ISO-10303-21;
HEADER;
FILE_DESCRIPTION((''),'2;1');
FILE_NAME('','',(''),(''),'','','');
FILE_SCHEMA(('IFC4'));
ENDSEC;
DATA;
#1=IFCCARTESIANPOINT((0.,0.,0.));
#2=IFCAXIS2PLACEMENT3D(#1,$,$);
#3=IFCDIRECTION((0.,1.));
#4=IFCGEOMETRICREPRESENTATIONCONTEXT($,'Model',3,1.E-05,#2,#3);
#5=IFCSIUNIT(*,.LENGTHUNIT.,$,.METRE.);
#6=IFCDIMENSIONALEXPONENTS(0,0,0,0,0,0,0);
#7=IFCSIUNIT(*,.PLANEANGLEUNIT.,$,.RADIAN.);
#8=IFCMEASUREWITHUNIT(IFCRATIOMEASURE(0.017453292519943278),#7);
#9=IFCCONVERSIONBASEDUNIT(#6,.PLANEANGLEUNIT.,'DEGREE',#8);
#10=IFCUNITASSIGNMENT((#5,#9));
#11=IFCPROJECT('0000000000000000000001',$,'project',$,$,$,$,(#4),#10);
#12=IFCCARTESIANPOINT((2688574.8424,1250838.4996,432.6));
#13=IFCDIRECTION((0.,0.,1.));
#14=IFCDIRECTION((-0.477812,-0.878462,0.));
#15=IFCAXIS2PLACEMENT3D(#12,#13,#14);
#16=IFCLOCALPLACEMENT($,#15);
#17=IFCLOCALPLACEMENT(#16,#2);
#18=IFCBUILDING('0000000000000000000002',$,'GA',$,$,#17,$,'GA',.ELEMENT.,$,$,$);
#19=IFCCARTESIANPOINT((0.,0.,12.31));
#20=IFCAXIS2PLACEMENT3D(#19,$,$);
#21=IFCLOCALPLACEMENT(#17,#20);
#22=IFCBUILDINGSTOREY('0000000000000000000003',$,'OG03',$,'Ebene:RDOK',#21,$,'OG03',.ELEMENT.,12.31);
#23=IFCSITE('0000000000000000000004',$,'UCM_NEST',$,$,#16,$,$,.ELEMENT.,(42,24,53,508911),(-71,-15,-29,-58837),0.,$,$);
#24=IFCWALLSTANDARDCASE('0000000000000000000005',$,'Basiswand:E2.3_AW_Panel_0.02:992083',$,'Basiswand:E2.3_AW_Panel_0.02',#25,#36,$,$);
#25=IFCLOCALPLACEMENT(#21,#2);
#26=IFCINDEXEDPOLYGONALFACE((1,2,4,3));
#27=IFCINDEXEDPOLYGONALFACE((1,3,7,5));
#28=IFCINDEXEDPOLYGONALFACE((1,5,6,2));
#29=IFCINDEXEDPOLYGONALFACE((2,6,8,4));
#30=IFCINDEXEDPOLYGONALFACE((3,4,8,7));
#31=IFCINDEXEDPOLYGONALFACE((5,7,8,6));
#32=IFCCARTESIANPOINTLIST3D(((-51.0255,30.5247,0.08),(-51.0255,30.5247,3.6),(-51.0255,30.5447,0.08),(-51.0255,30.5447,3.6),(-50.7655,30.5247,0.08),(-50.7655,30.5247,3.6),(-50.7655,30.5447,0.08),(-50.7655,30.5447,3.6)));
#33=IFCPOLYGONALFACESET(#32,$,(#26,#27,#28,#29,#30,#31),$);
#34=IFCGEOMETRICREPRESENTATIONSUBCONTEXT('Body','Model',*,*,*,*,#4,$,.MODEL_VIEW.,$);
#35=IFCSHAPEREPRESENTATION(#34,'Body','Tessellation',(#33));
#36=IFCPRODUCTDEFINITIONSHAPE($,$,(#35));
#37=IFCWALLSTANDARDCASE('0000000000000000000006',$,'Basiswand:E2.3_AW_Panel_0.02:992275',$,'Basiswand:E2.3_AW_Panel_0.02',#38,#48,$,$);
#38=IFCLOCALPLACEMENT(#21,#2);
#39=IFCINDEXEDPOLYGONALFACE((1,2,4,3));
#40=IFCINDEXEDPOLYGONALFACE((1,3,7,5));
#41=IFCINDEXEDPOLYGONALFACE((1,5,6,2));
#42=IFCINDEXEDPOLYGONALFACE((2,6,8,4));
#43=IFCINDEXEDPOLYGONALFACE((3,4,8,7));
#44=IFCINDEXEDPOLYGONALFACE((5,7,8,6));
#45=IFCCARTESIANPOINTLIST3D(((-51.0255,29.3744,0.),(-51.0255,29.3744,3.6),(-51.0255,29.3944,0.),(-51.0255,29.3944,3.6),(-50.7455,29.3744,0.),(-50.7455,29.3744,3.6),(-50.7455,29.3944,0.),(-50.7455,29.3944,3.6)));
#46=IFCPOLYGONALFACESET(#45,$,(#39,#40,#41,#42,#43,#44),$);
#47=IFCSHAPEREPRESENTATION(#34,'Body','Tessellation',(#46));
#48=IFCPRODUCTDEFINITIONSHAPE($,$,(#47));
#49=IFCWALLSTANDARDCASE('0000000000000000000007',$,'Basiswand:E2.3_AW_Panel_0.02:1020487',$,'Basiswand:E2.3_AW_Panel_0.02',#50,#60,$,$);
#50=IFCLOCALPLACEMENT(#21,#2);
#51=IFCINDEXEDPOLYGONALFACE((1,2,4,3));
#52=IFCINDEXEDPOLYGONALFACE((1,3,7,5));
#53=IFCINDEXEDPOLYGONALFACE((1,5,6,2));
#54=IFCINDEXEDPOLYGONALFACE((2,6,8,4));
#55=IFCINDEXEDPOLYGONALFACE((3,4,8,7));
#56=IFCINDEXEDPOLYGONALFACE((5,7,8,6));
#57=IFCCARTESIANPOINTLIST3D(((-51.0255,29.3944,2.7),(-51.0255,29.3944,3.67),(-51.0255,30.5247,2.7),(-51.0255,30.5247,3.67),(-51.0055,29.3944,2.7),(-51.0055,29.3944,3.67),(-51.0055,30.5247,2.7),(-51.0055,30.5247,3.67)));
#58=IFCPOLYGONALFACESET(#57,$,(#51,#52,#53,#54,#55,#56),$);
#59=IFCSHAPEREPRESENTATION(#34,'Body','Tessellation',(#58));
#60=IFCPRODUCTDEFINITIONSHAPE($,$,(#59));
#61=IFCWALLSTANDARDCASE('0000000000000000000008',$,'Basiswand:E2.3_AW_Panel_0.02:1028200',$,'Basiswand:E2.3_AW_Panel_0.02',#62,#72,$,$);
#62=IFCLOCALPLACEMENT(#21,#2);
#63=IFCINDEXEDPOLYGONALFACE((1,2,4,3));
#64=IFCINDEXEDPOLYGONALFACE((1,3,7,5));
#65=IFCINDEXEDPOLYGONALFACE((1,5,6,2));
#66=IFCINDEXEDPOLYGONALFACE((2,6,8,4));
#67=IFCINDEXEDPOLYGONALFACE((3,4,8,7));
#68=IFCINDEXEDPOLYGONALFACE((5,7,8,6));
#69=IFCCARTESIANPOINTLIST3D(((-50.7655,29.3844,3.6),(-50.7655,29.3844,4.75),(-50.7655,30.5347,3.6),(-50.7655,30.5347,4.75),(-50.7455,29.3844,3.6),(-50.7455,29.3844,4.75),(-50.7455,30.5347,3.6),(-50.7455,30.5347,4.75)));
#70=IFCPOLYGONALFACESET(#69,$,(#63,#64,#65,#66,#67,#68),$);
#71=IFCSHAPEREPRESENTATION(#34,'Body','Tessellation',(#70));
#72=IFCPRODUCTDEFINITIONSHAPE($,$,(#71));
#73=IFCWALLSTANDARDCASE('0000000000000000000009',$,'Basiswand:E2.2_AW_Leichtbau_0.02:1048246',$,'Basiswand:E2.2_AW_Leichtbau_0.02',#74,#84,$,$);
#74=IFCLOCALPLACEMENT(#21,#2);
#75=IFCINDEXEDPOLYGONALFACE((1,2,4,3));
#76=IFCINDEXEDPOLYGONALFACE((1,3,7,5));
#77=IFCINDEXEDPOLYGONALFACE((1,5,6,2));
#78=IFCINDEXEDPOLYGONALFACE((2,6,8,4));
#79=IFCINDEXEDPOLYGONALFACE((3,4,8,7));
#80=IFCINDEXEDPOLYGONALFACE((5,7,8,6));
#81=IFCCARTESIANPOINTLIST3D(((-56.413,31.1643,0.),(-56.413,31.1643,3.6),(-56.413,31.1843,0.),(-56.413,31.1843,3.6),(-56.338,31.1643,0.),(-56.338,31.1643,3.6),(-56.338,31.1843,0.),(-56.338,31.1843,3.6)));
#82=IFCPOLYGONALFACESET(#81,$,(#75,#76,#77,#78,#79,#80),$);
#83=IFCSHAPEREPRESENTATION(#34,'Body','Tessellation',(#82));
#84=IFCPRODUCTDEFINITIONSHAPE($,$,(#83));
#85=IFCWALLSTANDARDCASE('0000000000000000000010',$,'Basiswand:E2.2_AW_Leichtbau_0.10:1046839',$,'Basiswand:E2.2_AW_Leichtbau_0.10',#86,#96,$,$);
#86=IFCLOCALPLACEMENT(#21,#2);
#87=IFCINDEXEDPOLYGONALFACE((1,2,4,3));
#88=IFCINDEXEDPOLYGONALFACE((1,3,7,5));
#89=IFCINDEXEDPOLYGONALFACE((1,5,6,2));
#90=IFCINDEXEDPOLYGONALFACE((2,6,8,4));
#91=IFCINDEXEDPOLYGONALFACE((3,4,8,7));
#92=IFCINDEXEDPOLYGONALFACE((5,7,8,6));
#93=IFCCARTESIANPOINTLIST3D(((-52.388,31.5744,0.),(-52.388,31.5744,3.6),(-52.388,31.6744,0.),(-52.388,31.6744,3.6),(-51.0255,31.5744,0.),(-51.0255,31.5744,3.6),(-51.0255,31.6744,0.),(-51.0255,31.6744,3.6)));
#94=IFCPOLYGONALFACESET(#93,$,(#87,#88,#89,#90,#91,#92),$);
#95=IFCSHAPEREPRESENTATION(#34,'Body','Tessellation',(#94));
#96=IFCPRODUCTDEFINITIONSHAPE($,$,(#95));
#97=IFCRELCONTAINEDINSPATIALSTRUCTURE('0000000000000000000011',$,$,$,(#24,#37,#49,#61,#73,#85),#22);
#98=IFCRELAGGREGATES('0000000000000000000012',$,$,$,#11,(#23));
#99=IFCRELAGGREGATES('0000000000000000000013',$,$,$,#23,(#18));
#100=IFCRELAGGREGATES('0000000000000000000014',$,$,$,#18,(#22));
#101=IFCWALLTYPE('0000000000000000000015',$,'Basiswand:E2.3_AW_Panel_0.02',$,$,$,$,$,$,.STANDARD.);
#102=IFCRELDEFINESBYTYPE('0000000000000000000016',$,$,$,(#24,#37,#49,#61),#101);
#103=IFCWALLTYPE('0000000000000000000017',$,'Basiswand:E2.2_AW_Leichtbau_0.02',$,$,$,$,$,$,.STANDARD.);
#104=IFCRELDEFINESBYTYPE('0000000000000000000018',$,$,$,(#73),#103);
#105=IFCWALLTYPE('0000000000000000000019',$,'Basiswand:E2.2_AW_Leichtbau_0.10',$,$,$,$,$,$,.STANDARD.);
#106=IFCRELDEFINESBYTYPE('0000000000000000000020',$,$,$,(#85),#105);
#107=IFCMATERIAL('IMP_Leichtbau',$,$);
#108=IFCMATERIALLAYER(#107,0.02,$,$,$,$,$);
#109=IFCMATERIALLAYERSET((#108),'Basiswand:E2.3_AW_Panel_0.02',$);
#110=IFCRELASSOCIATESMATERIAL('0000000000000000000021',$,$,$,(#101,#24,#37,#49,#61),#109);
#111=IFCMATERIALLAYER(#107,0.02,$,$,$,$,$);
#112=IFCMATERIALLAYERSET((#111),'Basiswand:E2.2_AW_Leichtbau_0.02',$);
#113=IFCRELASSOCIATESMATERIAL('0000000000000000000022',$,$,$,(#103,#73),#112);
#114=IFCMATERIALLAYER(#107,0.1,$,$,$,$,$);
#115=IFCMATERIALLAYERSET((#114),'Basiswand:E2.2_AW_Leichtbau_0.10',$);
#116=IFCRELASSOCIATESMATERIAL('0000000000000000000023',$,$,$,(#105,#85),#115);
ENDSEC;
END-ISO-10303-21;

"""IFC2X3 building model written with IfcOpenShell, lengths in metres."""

from ifc_helpers import new_model, entity, si_unit, converted_unit, direction, frame, frame_2d, origin, place, context, subcontext, project, spatial, polyline, rectangle, extrude, clip, bounded_halfspace, material, layer, layer_set, layer_usage, type_object, element, save


model = new_model("IFC2X3")

# Units and contexts
model_context = context("Model", 3, precision=1e-05, world=origin(), true_north=direction((0.0, 1.0)))
body_context = subcontext(model_context, "Body", "Model", "MODEL_VIEW")
ifc_project = project(units=[si_unit("LENGTHUNIT", "METRE"), converted_unit("PLANEANGLEUNIT", "DEGREE", entity("IfcRatioMeasure", 0.017453292519943278), si_unit("PLANEANGLEUNIT", "RADIAN"), dimensions=[0, 0, 0, 0, 0, 0, 0])], contexts=[model_context])

# Site, building, storey
site_placement = place(None, frame((2688574.8424, 1250838.4996, 432.6), z_axis=(0.0, 0.0, 1.0), x_axis=(-0.477812, -0.878462, 0.0)))
site = spatial("IfcSite", under=ifc_project, at=site_placement, Name="UCM_NEST", CompositionType="ELEMENT", RefLatitude=(42, 24, 53, 508911), RefLongitude=(-71, -15, -29, -58837), RefElevation=0.0)
building_placement = place(site_placement, origin())
building = spatial("IfcBuilding", under=site, at=building_placement, Name="GA", LongName="GA", CompositionType="ELEMENT")
storey_placement = place(building_placement, frame((0.0, 0.0, 12.31)))
storey = spatial("IfcBuildingStorey", under=building, at=storey_placement, Name="OG03", ObjectType="Ebene:RDOK", LongName="OG03", CompositionType="ELEMENT", Elevation=12.31)

# Walls
ifc_material_1 = material(Name="IMP_Leichtbau")
ifc_layer_1 = layer(ifc_material_1, 0.02)
ifc_layer_set_1 = layer_set([ifc_layer_1], Name="Basiswand:E2.3_AW_Panel_0.02")
ifc_layer_usage_1 = layer_usage(ifc_layer_set_1, "AXIS2", "NEGATIVE", 0.01)
wall_type_1 = type_object("IfcWallType", Name="Basiswand:E2.3_AW_Panel_0.02", PredefinedType="STANDARD", material=ifc_layer_set_1)
wall_1_placement = place(storey_placement, frame((-50.7655, 30.5347, 0.08), z_axis=(0.0, 0.0, 1.0), x_axis=(-1.0, 0.0, 0.0)))
element("IfcWallStandardCase", 1, at=wall_1_placement, inside=storey, type_object=wall_type_1, material=ifc_layer_usage_1, Name="Basiswand:E2.3_AW_Panel_0.02:992083", ObjectType="Basiswand:E2.3_AW_Panel_0.02", context=body_context, shape_type="Clipping", body=[
    clip(extrude(rectangle(XDim=0.26, YDim=0.02, at=frame_2d((0.13, 0.0), x_axis=(-1.0, 0.0))), origin(), (0.0, 0.0, 1.0), 3.52), bounded_halfspace(frame((0.26, -0.01, 0.0)), True, frame((0.26, -0.01, 0.0)), polyline([(0.0, 0.0), (0.0, 0.02), (-0.26, 0.02), (-0.26, 0.0), (0.0, 0.0)]))),
])
wall_2_placement = place(storey_placement, frame((-51.0255, 29.3844, 0.0)))
element("IfcWallStandardCase", 2, at=wall_2_placement, inside=storey, type_object=wall_type_1, material=ifc_layer_usage_1, Name="Basiswand:E2.3_AW_Panel_0.02:992275", ObjectType="Basiswand:E2.3_AW_Panel_0.02", context=body_context, shape_type="SweptSolid", body=[
    extrude(rectangle(XDim=0.28, YDim=0.02, at=frame_2d((0.14, 0.0), x_axis=(-1.0, 0.0))), origin(), (0.0, 0.0, 1.0), 3.6),
])
wall_3_placement = place(storey_placement, frame((-51.0155, 30.5247, 2.7), z_axis=(0.0, 0.0, 1.0), x_axis=(0.0, -1.0, 0.0)))
element("IfcWallStandardCase", 3, at=wall_3_placement, inside=storey, type_object=wall_type_1, material=ifc_layer_usage_1, Name="Basiswand:E2.3_AW_Panel_0.02:1020487", ObjectType="Basiswand:E2.3_AW_Panel_0.02", context=body_context, shape_type="SweptSolid", body=[
    extrude(rectangle(XDim=1.1302, YDim=0.02, at=frame_2d((0.5651, 0.0), x_axis=(-1.0, 0.0))), origin(), (0.0, 0.0, 1.0), 0.97),
])
wall_4_placement = place(storey_placement, frame((-50.7555, 29.3844, 3.6), z_axis=(0.0, 0.0, 1.0), x_axis=(0.0, 1.0, 0.0)))
element("IfcWallStandardCase", 4, at=wall_4_placement, inside=storey, type_object=wall_type_1, material=ifc_layer_usage_1, Name="Basiswand:E2.3_AW_Panel_0.02:1028200", ObjectType="Basiswand:E2.3_AW_Panel_0.02", context=body_context, shape_type="SweptSolid", body=[
    extrude(rectangle(XDim=1.1502, YDim=0.02, at=frame_2d((0.5751, 0.0), x_axis=(-1.0, 0.0))), origin(), (0.0, 0.0, 1.0), 1.15),
])

# Walls
ifc_layer_2 = layer(ifc_material_1, 0.02)
ifc_layer_set_2 = layer_set([ifc_layer_2], Name="Basiswand:E2.2_AW_Leichtbau_0.02")
ifc_layer_usage_2 = layer_usage(ifc_layer_set_2, "AXIS2", "NEGATIVE", 0.01)
wall_type_2 = type_object("IfcWallType", Name="Basiswand:E2.2_AW_Leichtbau_0.02", PredefinedType="STANDARD", material=ifc_layer_set_2)
wall_5_placement = place(storey_placement, frame((-56.338, 31.1743, 0.0), z_axis=(0.0, 0.0, 1.0), x_axis=(-1.0, 0.0, 0.0)))
element("IfcWallStandardCase", 5, at=wall_5_placement, inside=storey, type_object=wall_type_2, material=ifc_layer_usage_2, Name="Basiswand:E2.2_AW_Leichtbau_0.02:1048246", ObjectType="Basiswand:E2.2_AW_Leichtbau_0.02", context=body_context, shape_type="SweptSolid", body=[
    extrude(rectangle(XDim=0.075, YDim=0.02, at=frame_2d((0.0375, 0.0), x_axis=(-1.0, 0.0))), origin(), (0.0, 0.0, 1.0), 3.6),
])
ifc_layer_3 = layer(ifc_material_1, 0.1)
ifc_layer_set_3 = layer_set([ifc_layer_3], Name="Basiswand:E2.2_AW_Leichtbau_0.10")
ifc_layer_usage_3 = layer_usage(ifc_layer_set_3, "AXIS2", "NEGATIVE", 0.05)
wall_type_3 = type_object("IfcWallType", Name="Basiswand:E2.2_AW_Leichtbau_0.10", PredefinedType="STANDARD", material=ifc_layer_set_3)
wall_6_placement = place(storey_placement, frame((-51.0255, 31.6244, 0.0), z_axis=(0.0, 0.0, 1.0), x_axis=(-1.0, 0.0, 0.0)))
element("IfcWallStandardCase", 6, at=wall_6_placement, inside=storey, type_object=wall_type_3, material=ifc_layer_usage_3, Name="Basiswand:E2.2_AW_Leichtbau_0.10:1046839", ObjectType="Basiswand:E2.2_AW_Leichtbau_0.10", context=body_context, shape_type="SweptSolid", body=[
    extrude(rectangle(XDim=1.3625, YDim=0.1, at=frame_2d((0.6812, 0.0), x_axis=(-1.0, 0.0))), origin(), (0.0, 0.0, 1.0), 3.6),
])

save(model, "model.ifc")
